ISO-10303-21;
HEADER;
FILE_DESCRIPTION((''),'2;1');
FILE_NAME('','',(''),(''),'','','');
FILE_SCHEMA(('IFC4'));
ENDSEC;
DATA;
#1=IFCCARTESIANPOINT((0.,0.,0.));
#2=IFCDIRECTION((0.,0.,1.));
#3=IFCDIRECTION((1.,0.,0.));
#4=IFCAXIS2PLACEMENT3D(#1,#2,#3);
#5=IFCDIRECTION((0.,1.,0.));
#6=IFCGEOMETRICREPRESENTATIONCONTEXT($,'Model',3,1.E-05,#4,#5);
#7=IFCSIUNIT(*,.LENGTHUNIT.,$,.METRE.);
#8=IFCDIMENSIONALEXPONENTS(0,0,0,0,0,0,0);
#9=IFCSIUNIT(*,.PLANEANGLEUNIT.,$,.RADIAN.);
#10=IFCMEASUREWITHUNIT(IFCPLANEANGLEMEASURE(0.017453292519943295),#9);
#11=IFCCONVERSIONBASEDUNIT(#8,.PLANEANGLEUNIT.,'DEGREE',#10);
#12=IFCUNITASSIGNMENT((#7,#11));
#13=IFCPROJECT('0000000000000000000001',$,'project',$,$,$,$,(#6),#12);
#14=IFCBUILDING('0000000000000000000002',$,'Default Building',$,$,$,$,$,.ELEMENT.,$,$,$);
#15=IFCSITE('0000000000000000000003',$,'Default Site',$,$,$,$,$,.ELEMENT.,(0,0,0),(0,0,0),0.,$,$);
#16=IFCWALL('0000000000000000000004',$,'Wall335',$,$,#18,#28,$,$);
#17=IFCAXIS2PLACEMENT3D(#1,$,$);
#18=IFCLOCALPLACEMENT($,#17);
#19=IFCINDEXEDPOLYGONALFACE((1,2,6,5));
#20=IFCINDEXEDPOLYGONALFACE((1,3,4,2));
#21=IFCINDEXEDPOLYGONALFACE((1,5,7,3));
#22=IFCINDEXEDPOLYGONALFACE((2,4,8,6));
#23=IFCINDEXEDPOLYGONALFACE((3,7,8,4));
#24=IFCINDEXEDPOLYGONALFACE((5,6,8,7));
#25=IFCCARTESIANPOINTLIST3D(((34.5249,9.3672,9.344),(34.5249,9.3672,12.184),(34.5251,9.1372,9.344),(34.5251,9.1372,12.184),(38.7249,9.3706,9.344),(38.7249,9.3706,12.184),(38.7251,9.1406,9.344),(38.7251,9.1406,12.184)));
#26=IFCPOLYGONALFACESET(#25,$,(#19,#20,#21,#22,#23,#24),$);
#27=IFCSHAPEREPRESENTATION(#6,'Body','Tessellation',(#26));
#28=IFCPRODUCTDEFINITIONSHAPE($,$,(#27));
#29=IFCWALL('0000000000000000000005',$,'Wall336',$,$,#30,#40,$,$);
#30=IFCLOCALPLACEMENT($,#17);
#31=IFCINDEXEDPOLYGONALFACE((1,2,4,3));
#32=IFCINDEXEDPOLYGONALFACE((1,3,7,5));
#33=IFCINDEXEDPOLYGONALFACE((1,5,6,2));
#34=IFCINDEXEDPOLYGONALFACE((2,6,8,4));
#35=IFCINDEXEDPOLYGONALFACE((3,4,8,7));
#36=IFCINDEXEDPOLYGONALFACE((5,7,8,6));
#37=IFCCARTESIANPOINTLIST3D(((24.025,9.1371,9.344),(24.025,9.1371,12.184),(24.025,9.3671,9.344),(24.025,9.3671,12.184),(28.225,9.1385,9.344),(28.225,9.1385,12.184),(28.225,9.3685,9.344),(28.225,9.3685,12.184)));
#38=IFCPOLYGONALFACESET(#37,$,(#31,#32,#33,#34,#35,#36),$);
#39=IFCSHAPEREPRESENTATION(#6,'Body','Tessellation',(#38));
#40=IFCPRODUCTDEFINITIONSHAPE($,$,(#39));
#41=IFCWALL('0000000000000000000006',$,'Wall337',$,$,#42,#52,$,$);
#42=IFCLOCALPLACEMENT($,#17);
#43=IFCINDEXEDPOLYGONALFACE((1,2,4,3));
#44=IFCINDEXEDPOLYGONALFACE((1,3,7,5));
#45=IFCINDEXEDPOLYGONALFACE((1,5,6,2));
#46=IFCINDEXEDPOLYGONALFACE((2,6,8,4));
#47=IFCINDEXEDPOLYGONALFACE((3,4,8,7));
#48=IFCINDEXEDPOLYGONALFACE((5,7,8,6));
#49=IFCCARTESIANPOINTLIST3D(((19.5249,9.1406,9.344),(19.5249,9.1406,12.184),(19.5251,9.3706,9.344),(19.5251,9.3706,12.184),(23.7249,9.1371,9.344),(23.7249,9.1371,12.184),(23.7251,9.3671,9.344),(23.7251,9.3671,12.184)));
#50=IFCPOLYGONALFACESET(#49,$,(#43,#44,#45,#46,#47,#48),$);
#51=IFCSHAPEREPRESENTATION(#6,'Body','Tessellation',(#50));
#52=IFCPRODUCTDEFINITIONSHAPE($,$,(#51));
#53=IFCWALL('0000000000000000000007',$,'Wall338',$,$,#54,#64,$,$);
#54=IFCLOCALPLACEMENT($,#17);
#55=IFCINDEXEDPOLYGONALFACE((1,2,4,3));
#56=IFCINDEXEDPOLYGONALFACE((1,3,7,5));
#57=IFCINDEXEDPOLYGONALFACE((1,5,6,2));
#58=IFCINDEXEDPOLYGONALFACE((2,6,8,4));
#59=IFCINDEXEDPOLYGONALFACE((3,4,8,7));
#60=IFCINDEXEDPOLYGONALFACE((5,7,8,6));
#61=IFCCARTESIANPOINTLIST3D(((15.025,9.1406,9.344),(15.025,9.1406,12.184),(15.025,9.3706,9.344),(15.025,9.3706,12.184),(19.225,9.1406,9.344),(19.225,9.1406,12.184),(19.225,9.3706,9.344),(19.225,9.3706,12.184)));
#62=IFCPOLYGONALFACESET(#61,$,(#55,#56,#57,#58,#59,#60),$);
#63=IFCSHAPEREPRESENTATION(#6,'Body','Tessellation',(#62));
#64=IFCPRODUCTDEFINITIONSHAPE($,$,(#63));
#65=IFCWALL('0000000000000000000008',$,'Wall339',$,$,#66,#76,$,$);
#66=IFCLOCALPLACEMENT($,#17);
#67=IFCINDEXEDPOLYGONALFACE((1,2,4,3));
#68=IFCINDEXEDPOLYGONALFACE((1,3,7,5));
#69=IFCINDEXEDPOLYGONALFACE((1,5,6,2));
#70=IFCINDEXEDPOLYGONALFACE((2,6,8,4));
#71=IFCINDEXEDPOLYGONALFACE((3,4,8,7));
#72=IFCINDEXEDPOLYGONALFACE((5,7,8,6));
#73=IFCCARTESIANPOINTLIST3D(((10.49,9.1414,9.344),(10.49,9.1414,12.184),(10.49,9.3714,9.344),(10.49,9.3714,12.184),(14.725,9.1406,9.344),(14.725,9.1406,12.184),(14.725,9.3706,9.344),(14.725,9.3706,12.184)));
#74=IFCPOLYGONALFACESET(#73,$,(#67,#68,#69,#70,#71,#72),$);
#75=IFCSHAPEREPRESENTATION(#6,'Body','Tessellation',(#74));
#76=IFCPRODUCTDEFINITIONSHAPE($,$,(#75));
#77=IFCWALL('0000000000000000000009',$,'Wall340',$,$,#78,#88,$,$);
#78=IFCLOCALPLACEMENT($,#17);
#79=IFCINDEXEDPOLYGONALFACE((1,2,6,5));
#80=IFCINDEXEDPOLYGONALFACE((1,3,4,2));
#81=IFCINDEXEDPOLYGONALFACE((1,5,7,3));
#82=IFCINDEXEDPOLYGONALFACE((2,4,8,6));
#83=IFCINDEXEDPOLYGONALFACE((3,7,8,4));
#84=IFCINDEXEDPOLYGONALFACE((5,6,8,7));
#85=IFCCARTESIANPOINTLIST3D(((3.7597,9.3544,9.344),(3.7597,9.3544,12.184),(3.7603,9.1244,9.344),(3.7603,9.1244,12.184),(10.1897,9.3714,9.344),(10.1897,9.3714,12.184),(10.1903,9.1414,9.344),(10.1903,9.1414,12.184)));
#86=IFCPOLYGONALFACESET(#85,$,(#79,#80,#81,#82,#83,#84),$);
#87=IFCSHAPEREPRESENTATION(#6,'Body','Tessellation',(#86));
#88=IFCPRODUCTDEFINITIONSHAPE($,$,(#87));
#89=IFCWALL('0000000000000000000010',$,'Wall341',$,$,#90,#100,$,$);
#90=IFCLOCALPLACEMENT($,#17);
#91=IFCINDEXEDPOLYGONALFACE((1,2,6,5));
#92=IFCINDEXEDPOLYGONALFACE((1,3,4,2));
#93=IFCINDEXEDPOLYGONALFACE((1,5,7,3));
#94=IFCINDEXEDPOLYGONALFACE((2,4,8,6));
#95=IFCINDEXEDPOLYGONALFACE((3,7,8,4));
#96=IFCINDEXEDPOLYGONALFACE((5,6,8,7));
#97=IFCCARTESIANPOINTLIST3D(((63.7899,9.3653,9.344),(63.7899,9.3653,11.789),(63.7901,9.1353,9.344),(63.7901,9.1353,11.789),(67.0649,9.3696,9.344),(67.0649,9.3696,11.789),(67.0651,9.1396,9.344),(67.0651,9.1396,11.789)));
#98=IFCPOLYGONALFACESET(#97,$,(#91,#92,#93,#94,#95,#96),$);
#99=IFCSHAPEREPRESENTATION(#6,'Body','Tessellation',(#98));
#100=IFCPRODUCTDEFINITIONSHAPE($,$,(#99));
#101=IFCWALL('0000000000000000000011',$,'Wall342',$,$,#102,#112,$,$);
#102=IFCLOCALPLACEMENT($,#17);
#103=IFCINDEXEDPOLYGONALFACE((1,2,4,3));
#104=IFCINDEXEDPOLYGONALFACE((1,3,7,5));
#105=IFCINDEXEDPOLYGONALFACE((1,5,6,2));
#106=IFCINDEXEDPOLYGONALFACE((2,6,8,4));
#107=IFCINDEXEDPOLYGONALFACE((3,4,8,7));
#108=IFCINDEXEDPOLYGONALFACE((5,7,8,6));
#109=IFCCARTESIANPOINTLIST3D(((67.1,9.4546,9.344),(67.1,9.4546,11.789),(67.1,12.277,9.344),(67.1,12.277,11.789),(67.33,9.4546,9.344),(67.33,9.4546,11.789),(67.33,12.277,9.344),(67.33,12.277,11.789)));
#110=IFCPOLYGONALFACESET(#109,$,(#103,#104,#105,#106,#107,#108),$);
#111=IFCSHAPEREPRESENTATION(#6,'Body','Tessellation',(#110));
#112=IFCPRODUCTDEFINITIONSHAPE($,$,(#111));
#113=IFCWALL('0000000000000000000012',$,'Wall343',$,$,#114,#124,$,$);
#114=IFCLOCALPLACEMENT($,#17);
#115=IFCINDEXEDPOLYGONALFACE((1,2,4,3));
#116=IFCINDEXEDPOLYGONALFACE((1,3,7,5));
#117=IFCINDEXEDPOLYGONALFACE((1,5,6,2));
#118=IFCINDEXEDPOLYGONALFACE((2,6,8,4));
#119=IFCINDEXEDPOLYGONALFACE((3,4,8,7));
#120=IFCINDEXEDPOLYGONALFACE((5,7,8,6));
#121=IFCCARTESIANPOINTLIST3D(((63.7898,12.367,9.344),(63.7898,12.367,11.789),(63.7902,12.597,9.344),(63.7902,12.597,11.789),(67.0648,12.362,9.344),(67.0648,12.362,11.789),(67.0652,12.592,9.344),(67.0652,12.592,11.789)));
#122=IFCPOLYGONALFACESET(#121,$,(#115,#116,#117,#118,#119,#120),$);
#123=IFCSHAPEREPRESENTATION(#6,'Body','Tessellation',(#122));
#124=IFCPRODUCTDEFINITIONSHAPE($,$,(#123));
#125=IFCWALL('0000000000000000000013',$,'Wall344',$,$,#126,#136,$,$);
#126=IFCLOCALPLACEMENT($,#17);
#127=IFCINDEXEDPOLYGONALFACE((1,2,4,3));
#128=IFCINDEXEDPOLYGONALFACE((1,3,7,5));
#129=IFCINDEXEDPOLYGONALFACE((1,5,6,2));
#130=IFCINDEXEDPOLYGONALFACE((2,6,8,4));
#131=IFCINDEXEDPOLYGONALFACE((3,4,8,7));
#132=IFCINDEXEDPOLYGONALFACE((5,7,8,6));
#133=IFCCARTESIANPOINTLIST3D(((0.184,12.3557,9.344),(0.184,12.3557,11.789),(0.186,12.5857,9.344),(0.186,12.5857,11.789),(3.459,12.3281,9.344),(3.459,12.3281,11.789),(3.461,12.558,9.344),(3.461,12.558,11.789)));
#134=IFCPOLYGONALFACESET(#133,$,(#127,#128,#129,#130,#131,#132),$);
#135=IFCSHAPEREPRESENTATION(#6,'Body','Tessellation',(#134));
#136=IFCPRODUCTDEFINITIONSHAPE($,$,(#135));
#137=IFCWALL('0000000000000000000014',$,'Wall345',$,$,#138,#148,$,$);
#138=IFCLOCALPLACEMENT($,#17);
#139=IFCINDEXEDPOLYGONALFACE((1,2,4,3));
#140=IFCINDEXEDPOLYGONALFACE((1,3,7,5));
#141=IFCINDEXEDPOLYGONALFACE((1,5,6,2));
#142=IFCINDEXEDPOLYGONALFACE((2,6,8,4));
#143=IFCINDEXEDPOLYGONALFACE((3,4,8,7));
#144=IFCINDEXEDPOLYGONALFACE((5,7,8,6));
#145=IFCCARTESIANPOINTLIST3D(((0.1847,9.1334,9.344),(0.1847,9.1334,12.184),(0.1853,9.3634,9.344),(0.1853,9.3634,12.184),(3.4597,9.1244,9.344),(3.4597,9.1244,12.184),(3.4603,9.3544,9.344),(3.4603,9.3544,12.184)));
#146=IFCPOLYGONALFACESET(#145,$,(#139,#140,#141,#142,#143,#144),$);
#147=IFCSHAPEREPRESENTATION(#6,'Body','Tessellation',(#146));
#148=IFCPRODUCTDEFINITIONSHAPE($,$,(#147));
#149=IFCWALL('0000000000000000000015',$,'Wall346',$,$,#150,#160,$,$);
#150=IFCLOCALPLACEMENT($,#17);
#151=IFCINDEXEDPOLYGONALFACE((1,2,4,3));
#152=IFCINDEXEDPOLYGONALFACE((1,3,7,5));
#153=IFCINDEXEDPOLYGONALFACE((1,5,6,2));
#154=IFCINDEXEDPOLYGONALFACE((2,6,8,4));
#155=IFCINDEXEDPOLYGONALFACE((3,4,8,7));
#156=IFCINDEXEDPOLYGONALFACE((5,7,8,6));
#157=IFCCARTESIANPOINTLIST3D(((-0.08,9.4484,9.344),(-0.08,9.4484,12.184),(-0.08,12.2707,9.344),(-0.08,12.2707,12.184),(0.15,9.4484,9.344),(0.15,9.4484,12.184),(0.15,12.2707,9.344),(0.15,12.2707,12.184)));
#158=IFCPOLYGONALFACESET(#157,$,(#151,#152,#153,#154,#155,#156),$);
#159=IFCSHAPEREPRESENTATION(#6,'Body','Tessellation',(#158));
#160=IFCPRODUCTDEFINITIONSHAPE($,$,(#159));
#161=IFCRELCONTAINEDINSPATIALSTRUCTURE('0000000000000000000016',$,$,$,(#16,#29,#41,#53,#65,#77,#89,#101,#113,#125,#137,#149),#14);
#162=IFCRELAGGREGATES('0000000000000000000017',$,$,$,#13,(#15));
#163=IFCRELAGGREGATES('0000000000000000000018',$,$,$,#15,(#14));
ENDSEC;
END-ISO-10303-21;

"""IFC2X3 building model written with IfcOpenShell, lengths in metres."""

from ifc_helpers import new_model, entity, si_unit, converted_unit, direction, frame, frame_2d, origin_with_axes, place, context, project, spatial, rectangle, extrude, element, save


model = new_model("IFC2X3")

# Units and contexts
model_context = context("Model", 3, precision=1e-05, world=origin_with_axes(), true_north=direction((0.0, 1.0, 0.0)))
ifc_project = project(units=[si_unit("LENGTHUNIT", "METRE"), converted_unit("PLANEANGLEUNIT", "DEGREE", entity("IfcPlaneAngleMeasure", 0.017453292519943295), si_unit("PLANEANGLEUNIT", "RADIAN"), dimensions=[0, 0, 0, 0, 0, 0, 0])], contexts=[model_context])

# Site, building
site = spatial("IfcSite", under=ifc_project, Name="Default Site", CompositionType="ELEMENT", RefLatitude=(0, 0, 0), RefLongitude=(0, 0, 0), RefElevation=0.0)
building = spatial("IfcBuilding", under=site, Name="Default Building", CompositionType="ELEMENT")

# Shared definitions
placement = place(None, origin_with_axes())

# Walls
element("IfcWall", 1, at=placement, inside=building, Name="Wall335", context=model_context, shape_type="SweptSolid", body=[
    extrude(rectangle(XDim=4.2, YDim=0.23, at=frame_2d((0.0, 0.0), x_axis=(1.0, 0.000801, 0.0))), frame((36.625, 9.2539, 9.344), z_axis=(0.0, 0.0, 1.0), x_axis=(1.0, 0.0, 0.0)), (0.0, 0.0, 1.0), 2.84),
])
element("IfcWall", 2, at=placement, inside=building, Name="Wall336", context=model_context, shape_type="SweptSolid", body=[
    extrude(rectangle(XDim=4.2, YDim=0.23, at=frame_2d((0.0, 0.0), x_axis=(-1.0, -0.000329, 0.0))), frame((26.125, 9.2528, 9.344), z_axis=(0.0, 0.0, 1.0), x_axis=(1.0, 0.0, 0.0)), (0.0, 0.0, 1.0), 2.84),
])
element("IfcWall", 3, at=placement, inside=building, Name="Wall337", context=model_context, shape_type="SweptSolid", body=[
    extrude(rectangle(XDim=4.2, YDim=0.23, at=frame_2d((0.0, 0.0), x_axis=(-1.0, 0.000835, 0.0))), frame((21.625, 9.2539, 9.344), z_axis=(0.0, 0.0, 1.0), x_axis=(1.0, 0.0, 0.0)), (0.0, 0.0, 1.0), 2.84),
])
element("IfcWall", 4, at=placement, inside=building, Name="Wall338", context=model_context, shape_type="SweptSolid", body=[
    extrude(rectangle(XDim=4.2, YDim=0.23, at=frame_2d((0.0, 0.0), x_axis=(-1.0, -0.000014, 0.0))), frame((17.125, 9.2556, 9.344), z_axis=(0.0, 0.0, 1.0), x_axis=(1.0, 0.0, 0.0)), (0.0, 0.0, 1.0), 2.84),
])
element("IfcWall", 5, at=placement, inside=building, Name="Wall339", context=model_context, shape_type="SweptSolid", body=[
    extrude(rectangle(XDim=4.235, YDim=0.23, at=frame_2d((0.0, 0.0), x_axis=(1.0, -0.000195, 0.0))), frame((12.6075, 9.256, 9.344), z_axis=(0.0, 0.0, 1.0), x_axis=(1.0, 0.0, 0.0)), (0.0, 0.0, 1.0), 2.84),
])
element("IfcWall", 6, at=placement, inside=building, Name="Wall340", context=model_context, shape_type="SweptSolid", body=[
    extrude(rectangle(XDim=6.43, YDim=0.23, at=frame_2d((0.0, 0.0), x_axis=(-0.999997, -0.002639, 0.0))), frame((6.975, 9.2479, 9.344), z_axis=(0.0, 0.0, 1.0), x_axis=(1.0, 0.0, 0.0)), (0.0, 0.0, 1.0), 2.84),
])
element("IfcWall", 7, at=placement, inside=building, Name="Wall341", context=model_context, shape_type="SweptSolid", body=[
    extrude(rectangle(XDim=3.275, YDim=0.23, at=frame_2d((0.0, 0.0), x_axis=(0.999999, 0.001297, 0.0))), frame((65.4275, 9.2525, 9.344), z_axis=(0.0, 0.0, 1.0), x_axis=(1.0, 0.0, 0.0)), (0.0, 0.0, 1.0), 2.445),
])
element("IfcWall", 8, at=placement, inside=building, Name="Wall342", context=model_context, shape_type="SweptSolid", body=[
    extrude(rectangle(XDim=2.8224, YDim=0.23, at=frame_2d((0.0, 0.0), x_axis=(0.0, -1.0, 0.0))), frame((67.215, 10.8658, 9.344), z_axis=(0.0, 0.0, 1.0), x_axis=(1.0, 0.0, 0.0)), (0.0, 0.0, 1.0), 2.445),
])
element("IfcWall", 9, at=placement, inside=building, Name="Wall343", context=model_context, shape_type="SweptSolid", body=[
    extrude(rectangle(XDim=3.275, YDim=0.23, at=frame_2d((0.0, 0.0), x_axis=(0.999999, -0.001506, 0.0))), frame((65.4275, 12.4795, 9.344), z_axis=(0.0, 0.0, 1.0), x_axis=(1.0, 0.0, 0.0)), (0.0, 0.0, 1.0), 2.445),
])
element("IfcWall", 10, at=placement, inside=building, Name="Wall344", context=model_context, shape_type="SweptSolid", body=[
    extrude(rectangle(XDim=3.2751, YDim=0.23, at=frame_2d((0.0, 0.0), x_axis=(-0.999964, 0.008443, 0.0))), frame((1.8225, 12.4569, 9.344), z_axis=(0.0, 0.0, 1.0), x_axis=(1.0, 0.0, 0.0)), (0.0, 0.0, 1.0), 2.445),
])
element("IfcWall", 11, at=placement, inside=building, Name="Wall345", context=model_context, shape_type="SweptSolid", body=[
    extrude(rectangle(XDim=3.275, YDim=0.23, at=frame_2d((0.0, 0.0), x_axis=(0.999996, -0.002728, 0.0))), frame((1.8225, 9.2439, 9.344), z_axis=(0.0, 0.0, 1.0), x_axis=(1.0, 0.0, 0.0)), (0.0, 0.0, 1.0), 2.84),
])
element("IfcWall", 12, at=placement, inside=building, Name="Wall346", context=model_context, shape_type="SweptSolid", body=[
    extrude(rectangle(XDim=2.8223, YDim=0.23, at=frame_2d((0.0, 0.0), x_axis=(0.0, 1.0, 0.0))), frame((0.035, 10.8595, 9.344), z_axis=(0.0, 0.0, 1.0), x_axis=(1.0, 0.0, 0.0)), (0.0, 0.0, 1.0), 2.84),
])

save(model, "model.ifc")
